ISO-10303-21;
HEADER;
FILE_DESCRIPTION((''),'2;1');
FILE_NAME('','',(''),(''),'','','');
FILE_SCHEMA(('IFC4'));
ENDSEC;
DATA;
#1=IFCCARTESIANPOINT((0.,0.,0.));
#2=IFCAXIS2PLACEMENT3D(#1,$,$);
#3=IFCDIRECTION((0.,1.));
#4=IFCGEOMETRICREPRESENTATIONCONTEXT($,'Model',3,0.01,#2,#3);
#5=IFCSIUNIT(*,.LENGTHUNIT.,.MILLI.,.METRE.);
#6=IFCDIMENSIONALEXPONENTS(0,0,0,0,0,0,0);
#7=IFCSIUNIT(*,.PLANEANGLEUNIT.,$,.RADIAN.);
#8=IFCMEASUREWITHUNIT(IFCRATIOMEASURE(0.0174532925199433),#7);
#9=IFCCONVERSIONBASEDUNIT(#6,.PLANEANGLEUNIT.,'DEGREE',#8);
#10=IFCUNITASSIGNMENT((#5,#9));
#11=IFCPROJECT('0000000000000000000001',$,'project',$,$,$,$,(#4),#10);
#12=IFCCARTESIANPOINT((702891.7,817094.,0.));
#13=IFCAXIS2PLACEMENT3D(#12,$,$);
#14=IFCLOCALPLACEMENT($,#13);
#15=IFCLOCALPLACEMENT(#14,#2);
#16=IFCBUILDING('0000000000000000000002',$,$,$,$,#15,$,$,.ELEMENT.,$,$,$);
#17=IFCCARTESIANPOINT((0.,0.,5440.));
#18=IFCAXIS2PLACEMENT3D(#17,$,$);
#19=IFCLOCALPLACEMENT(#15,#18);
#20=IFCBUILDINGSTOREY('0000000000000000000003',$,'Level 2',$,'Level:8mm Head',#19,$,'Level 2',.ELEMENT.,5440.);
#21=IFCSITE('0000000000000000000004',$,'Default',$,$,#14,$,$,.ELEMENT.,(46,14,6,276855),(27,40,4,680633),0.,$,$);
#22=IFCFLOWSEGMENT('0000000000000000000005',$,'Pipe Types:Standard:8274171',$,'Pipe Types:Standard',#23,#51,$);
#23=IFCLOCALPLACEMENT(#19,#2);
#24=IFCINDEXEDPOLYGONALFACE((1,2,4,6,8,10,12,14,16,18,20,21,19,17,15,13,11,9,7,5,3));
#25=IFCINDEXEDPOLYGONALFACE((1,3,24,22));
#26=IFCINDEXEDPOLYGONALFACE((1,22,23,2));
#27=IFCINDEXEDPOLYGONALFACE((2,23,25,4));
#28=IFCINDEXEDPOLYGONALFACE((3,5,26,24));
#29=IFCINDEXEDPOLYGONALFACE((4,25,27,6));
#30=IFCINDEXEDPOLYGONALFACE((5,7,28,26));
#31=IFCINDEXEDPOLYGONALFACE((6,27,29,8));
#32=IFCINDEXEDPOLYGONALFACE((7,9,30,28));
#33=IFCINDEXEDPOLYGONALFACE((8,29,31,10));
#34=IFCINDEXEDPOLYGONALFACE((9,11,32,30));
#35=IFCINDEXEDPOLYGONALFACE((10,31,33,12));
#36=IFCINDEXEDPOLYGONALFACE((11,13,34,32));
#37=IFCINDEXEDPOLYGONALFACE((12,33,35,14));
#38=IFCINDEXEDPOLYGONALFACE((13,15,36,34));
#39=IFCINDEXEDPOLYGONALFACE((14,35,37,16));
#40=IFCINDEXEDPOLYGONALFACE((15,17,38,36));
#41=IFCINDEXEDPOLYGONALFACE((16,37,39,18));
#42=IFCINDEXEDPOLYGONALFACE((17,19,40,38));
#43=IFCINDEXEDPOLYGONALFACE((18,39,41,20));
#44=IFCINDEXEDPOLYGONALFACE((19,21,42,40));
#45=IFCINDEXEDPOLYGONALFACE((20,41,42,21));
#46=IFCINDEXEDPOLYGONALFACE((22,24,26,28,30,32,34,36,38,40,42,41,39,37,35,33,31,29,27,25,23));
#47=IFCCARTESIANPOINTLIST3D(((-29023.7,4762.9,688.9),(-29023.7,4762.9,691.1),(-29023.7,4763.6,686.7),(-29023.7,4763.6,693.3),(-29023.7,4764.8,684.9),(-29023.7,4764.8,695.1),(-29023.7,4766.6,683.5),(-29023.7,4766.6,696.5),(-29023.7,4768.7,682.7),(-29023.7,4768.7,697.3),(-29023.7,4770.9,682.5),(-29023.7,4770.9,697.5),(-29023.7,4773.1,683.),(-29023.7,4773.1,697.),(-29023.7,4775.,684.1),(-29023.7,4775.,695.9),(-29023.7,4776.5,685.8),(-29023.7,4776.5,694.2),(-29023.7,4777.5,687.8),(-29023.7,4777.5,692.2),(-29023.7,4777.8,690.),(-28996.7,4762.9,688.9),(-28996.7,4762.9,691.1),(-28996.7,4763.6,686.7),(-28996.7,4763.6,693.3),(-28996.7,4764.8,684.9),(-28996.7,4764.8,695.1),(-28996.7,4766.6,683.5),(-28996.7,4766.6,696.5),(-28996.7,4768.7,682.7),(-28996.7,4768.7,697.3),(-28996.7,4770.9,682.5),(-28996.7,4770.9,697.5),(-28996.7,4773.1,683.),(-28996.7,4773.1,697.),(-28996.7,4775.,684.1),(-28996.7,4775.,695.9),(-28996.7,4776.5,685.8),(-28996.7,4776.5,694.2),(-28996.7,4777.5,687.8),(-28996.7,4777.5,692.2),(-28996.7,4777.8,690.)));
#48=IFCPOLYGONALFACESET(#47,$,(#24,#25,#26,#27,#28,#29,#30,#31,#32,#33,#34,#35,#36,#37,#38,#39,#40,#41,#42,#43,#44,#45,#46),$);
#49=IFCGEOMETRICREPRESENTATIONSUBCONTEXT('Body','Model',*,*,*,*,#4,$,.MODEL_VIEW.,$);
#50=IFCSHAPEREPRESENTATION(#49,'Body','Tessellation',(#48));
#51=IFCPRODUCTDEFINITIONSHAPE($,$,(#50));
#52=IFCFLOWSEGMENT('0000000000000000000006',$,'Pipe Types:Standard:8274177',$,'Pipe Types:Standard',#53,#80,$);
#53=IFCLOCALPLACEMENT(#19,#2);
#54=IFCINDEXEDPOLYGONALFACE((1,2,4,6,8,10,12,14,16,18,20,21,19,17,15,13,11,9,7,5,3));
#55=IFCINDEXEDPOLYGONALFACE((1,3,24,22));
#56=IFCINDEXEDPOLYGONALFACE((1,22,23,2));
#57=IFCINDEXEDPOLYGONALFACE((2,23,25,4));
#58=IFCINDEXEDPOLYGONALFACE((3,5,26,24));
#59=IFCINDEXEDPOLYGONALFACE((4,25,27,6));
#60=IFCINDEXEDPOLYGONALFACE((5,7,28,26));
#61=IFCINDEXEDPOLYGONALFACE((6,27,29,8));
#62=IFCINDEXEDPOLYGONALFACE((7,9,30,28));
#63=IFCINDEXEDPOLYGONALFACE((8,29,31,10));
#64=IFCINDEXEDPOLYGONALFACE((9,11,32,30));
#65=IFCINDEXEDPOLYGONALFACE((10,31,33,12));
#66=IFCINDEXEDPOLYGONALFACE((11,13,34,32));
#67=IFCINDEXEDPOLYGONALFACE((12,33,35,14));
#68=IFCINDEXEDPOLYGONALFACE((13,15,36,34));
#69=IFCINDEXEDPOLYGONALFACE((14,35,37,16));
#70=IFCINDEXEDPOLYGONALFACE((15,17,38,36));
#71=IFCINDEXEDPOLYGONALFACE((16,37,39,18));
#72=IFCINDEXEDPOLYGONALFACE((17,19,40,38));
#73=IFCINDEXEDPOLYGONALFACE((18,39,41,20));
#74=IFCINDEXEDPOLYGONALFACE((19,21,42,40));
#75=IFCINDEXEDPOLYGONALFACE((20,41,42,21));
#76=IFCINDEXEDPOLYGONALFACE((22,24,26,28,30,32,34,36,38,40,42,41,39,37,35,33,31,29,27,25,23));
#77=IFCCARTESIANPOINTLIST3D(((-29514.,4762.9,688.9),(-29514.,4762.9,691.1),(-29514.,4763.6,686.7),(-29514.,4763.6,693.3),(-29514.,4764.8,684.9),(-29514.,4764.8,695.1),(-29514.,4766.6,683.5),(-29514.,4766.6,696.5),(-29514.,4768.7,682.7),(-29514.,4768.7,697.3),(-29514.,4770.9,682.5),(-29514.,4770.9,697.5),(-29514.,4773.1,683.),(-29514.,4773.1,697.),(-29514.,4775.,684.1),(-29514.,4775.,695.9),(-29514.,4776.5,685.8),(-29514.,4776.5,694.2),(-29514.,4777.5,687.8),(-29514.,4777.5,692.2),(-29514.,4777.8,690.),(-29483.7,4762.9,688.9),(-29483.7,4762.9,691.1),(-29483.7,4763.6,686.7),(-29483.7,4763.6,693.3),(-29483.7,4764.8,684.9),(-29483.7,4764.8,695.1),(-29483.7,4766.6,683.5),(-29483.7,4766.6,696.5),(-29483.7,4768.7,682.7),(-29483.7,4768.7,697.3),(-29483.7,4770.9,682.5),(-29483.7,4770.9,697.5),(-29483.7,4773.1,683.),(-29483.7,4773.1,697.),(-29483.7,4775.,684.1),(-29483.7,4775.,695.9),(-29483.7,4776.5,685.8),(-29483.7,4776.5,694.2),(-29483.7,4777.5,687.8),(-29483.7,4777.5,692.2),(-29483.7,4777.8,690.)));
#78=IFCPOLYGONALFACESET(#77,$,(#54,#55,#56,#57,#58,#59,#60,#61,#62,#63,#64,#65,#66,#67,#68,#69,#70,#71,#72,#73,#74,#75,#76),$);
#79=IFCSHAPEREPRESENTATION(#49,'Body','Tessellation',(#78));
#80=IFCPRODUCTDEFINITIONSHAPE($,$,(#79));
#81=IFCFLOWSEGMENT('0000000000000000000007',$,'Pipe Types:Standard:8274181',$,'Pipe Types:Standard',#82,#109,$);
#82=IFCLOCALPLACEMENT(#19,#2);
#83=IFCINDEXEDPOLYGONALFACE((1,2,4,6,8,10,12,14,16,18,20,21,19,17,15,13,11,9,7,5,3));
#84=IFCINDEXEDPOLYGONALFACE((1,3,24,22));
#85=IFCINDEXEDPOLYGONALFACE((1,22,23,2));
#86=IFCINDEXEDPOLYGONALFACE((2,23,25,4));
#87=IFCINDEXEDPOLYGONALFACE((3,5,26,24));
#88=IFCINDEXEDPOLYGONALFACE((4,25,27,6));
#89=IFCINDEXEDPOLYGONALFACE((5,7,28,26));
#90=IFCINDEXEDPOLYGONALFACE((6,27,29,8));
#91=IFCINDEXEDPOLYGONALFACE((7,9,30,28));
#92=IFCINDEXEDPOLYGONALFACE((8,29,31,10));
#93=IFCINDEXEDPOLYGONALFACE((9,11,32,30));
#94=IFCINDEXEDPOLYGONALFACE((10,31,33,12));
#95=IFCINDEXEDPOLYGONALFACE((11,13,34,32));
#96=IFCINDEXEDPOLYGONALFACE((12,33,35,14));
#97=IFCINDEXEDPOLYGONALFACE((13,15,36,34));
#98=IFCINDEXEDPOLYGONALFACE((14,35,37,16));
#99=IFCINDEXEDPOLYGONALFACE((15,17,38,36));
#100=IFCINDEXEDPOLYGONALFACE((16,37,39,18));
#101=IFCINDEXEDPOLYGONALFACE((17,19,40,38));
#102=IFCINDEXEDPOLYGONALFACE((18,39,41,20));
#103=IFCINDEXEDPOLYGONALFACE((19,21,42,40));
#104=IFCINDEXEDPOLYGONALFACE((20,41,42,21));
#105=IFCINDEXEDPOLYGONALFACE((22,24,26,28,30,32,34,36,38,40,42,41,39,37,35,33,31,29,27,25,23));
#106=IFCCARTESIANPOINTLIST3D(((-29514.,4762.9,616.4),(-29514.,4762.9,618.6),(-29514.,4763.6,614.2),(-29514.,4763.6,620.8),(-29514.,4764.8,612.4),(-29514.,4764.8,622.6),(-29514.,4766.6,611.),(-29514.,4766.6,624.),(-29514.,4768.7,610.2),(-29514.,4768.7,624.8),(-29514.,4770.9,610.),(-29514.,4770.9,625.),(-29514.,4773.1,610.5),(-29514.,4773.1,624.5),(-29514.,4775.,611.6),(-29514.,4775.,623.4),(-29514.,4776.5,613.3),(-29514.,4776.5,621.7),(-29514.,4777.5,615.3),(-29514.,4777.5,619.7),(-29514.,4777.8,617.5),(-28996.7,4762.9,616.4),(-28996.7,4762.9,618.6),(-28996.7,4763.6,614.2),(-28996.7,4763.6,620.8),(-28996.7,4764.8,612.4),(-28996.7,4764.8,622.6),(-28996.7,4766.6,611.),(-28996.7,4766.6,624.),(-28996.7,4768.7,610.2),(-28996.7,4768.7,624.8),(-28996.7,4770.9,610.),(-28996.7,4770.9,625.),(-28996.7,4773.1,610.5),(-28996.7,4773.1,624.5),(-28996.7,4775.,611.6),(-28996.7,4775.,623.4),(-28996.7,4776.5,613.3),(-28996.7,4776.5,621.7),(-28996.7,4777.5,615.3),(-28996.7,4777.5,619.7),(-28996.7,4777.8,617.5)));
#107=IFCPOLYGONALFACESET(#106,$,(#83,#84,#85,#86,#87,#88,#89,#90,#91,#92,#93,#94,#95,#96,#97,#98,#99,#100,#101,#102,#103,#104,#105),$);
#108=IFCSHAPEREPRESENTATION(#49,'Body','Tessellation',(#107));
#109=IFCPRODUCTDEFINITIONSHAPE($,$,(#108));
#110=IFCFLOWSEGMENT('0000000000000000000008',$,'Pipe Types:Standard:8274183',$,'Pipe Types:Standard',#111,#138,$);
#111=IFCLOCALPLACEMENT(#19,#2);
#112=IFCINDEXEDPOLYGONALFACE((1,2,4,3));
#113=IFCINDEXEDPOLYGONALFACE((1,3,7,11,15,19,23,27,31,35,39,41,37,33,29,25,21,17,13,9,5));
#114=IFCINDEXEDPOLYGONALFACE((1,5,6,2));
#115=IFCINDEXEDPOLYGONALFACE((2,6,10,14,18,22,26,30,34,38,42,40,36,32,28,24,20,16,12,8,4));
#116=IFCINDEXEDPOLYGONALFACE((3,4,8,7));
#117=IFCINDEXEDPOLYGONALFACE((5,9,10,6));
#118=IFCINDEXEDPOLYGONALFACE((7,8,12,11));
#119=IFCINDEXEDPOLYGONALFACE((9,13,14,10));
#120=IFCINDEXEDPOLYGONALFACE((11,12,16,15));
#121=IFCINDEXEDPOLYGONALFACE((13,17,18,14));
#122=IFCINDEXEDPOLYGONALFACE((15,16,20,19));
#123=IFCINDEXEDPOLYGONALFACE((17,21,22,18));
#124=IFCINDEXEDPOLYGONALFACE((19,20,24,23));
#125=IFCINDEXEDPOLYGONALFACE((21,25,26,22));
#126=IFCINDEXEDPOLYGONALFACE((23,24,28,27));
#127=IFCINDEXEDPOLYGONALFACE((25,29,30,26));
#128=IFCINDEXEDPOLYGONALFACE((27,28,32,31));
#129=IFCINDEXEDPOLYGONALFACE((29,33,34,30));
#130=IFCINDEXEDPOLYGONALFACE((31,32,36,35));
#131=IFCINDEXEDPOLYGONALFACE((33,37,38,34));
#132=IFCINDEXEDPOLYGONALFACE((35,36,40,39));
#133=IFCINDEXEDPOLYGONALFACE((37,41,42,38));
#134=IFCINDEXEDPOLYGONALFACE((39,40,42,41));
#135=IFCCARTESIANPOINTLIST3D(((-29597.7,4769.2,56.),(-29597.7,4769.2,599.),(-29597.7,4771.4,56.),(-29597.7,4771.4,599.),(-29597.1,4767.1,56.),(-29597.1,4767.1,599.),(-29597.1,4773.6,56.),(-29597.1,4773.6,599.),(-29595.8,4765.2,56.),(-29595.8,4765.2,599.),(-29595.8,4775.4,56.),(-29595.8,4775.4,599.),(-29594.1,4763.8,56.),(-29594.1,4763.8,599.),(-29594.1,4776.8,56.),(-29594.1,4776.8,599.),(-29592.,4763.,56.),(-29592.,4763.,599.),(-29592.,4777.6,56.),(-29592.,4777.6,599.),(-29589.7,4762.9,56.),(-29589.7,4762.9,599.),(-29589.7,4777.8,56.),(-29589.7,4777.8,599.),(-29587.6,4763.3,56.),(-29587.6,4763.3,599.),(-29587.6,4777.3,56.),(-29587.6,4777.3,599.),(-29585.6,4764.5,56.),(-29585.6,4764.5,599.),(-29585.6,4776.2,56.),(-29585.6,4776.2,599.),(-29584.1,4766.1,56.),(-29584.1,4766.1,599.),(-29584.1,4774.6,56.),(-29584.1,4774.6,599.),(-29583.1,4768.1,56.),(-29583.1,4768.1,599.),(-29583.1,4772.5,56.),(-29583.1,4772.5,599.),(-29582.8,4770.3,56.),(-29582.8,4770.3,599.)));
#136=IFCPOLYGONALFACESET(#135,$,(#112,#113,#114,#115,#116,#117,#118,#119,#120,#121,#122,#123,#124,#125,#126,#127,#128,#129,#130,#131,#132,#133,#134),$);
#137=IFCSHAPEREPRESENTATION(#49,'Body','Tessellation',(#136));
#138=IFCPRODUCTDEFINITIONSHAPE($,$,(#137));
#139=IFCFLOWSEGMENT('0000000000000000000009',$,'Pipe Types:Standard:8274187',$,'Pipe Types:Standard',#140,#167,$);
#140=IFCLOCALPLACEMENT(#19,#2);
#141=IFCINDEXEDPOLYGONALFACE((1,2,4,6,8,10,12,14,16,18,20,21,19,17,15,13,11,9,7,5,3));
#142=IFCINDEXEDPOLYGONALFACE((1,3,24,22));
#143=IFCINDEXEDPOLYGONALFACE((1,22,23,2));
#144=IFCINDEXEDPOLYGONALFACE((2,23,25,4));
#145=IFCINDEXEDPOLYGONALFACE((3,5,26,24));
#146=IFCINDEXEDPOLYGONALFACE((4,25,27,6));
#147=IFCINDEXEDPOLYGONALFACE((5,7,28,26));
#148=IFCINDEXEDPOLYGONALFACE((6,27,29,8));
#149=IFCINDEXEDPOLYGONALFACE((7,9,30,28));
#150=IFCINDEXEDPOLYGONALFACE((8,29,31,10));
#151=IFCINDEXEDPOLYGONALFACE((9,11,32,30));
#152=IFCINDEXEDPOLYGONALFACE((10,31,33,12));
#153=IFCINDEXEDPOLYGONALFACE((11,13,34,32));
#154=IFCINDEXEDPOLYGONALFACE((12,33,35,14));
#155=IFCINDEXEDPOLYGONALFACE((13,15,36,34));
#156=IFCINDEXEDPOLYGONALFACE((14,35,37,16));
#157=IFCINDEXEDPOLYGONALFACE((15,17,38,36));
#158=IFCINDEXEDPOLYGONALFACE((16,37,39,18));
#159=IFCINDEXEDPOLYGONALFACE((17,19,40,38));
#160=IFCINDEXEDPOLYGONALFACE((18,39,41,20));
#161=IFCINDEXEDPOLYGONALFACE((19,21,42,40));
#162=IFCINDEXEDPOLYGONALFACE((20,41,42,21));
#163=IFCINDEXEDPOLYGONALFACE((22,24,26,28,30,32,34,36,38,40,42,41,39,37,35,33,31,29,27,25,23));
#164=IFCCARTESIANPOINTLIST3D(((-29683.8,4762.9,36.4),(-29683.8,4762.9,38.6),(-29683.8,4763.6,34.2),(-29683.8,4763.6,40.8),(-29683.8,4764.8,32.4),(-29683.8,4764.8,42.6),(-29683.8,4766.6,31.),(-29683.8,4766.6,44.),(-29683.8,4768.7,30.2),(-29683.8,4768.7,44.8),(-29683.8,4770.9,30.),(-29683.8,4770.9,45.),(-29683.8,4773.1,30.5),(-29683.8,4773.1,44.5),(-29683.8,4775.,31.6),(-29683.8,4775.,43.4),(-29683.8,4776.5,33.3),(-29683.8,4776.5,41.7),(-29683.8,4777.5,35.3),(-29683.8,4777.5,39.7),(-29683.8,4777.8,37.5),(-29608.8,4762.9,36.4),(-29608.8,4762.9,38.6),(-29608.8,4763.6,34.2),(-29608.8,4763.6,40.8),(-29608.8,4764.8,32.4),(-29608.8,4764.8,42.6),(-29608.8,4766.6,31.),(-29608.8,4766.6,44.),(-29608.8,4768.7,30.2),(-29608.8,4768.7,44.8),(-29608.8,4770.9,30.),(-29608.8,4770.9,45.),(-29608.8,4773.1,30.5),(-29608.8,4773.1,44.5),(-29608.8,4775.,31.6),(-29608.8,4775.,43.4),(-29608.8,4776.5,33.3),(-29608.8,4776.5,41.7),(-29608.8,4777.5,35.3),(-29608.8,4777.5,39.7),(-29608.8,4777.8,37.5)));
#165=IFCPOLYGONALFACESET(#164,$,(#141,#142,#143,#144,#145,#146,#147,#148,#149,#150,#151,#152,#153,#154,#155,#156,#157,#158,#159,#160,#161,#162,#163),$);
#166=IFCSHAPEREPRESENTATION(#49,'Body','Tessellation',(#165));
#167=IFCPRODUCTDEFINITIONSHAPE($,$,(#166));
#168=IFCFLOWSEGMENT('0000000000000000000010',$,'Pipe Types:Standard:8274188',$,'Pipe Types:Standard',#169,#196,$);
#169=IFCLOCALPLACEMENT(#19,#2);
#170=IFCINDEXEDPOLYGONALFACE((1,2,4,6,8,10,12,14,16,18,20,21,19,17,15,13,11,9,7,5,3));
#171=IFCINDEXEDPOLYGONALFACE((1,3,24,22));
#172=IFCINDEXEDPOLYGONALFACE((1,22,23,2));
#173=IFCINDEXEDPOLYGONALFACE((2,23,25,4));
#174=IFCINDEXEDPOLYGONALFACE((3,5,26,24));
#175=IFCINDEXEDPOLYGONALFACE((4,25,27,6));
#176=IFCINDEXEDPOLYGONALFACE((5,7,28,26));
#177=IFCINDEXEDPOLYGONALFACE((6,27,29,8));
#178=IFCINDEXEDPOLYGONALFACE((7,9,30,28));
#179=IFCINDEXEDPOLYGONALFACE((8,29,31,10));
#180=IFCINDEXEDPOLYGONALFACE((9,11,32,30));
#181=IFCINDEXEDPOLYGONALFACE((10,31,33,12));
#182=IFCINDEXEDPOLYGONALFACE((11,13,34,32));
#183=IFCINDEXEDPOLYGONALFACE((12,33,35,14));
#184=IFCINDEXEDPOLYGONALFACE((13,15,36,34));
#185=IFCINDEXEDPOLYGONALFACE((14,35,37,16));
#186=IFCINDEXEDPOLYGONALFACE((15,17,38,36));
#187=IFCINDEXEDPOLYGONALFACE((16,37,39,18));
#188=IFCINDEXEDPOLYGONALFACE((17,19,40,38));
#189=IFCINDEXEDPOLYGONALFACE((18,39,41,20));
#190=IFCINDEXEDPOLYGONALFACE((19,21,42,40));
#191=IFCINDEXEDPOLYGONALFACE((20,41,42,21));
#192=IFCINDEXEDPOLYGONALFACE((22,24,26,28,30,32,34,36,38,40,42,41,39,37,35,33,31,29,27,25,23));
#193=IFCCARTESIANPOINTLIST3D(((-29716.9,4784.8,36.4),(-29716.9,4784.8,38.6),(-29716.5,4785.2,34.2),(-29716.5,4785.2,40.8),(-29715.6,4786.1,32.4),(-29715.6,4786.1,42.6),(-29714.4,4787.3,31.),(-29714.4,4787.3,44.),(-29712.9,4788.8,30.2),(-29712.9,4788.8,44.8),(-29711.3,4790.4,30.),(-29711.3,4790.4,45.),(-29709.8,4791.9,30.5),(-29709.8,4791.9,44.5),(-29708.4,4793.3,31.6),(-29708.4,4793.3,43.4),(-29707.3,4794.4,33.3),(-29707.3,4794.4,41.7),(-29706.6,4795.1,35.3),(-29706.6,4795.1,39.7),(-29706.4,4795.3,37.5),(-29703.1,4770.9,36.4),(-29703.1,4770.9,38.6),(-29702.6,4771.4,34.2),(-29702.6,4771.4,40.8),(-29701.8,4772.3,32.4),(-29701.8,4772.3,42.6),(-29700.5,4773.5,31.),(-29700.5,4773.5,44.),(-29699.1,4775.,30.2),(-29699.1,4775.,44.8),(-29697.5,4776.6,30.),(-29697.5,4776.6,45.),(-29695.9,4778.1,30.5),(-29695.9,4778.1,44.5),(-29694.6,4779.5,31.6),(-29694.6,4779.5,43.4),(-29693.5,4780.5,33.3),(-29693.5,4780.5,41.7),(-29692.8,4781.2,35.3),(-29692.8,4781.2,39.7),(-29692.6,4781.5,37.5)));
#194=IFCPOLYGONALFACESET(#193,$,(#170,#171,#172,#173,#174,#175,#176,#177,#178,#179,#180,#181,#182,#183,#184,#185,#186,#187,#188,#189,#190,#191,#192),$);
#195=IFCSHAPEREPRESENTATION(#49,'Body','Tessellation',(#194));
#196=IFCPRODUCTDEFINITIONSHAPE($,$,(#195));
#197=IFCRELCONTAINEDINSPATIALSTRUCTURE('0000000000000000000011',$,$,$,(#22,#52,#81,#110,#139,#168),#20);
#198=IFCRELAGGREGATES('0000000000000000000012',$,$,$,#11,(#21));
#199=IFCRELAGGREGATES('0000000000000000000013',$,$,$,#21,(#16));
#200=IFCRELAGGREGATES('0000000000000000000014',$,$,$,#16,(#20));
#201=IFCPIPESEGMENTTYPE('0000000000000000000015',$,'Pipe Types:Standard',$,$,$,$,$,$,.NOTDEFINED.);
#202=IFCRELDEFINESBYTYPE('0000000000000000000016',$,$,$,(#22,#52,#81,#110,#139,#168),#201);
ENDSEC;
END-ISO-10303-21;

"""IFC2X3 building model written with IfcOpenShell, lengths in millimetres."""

from ifc_helpers import new_model, entity, si_unit, converted_unit, direction, frame, frame_2d, origin, origin_2d_with_axis, place, context, subcontext, project, spatial, circle, extrude, type_object, element, save


model = new_model("IFC2X3")

# Units and contexts
model_context = context("Model", 3, precision=0.01, world=origin(), true_north=direction((0.0, 1.0)))
body_context = subcontext(model_context, "Body", "Model", "MODEL_VIEW")
ifc_project = project(units=[si_unit("LENGTHUNIT", "METRE", prefix="MILLI"), converted_unit("PLANEANGLEUNIT", "DEGREE", entity("IfcRatioMeasure", 0.0174532925199433), si_unit("PLANEANGLEUNIT", "RADIAN"), dimensions=[0, 0, 0, 0, 0, 0, 0])], contexts=[model_context])

# Site, building, storey
site_placement = place(None, frame((702891.7, 817094.0, 0.0)))
site = spatial("IfcSite", under=ifc_project, at=site_placement, Name="Default", CompositionType="ELEMENT", RefLatitude=(46, 14, 6, 276855), RefLongitude=(27, 40, 4, 680633), RefElevation=0.0)
building_placement = place(site_placement, origin())
building = spatial("IfcBuilding", under=site, at=building_placement, CompositionType="ELEMENT")
storey_placement = place(building_placement, frame((0.0, 0.0, 5440.0)))
storey = spatial("IfcBuildingStorey", under=building, at=storey_placement, Name="Level 2", ObjectType="Level:8mm Head", LongName="Level 2", CompositionType="ELEMENT", Elevation=5440.0)

# Flow segments
pipe_segment_type = type_object("IfcPipeSegmentType", Name="Pipe Types:Standard", PredefinedType="NOTDEFINED")
flow_segment_1_placement = place(storey_placement, origin())
element("IfcFlowSegment", 1, at=flow_segment_1_placement, inside=storey, type_object=pipe_segment_type, Name="Pipe Types:Standard:8274171", ObjectType="Pipe Types:Standard", context=body_context, shape_type="SweptSolid", body=[
    extrude(circle(Radius=7.5, at=frame_2d((0.0, 0.0), x_axis=(1.0, 0.0))), frame((-29023.7, 4770.3, 690.0), z_axis=(1.0, 0.0, 0.0), x_axis=(0.0, 1.0, 0.0)), (0.0, 0.0, 1.0), 27.0),
])
flow_segment_2_placement = place(storey_placement, origin())
element("IfcFlowSegment", 2, at=flow_segment_2_placement, inside=storey, type_object=pipe_segment_type, Name="Pipe Types:Standard:8274177", ObjectType="Pipe Types:Standard", context=body_context, shape_type="SweptSolid", body=[
    extrude(circle(Radius=7.5, at=frame_2d((0.0, 0.0), x_axis=(1.0, 0.0))), frame((-29514.0, 4770.3, 690.0), z_axis=(1.0, 0.0, 0.0), x_axis=(0.0, 1.0, 0.0)), (0.0, 0.0, 1.0), 30.3),
])
flow_segment_3_placement = place(storey_placement, origin())
element("IfcFlowSegment", 3, at=flow_segment_3_placement, inside=storey, type_object=pipe_segment_type, Name="Pipe Types:Standard:8274181", ObjectType="Pipe Types:Standard", context=body_context, shape_type="SweptSolid", body=[
    extrude(circle(Radius=7.5, at=frame_2d((0.0, 0.0), x_axis=(1.0, 0.0))), frame((-29514.0, 4770.3, 617.5), z_axis=(1.0, 0.0, 0.0), x_axis=(0.0, 1.0, 0.0)), (0.0, 0.0, 1.0), 517.3),
])
flow_segment_4_placement = place(storey_placement, origin())
element("IfcFlowSegment", 4, at=flow_segment_4_placement, inside=storey, type_object=pipe_segment_type, Name="Pipe Types:Standard:8274183", ObjectType="Pipe Types:Standard", context=body_context, shape_type="SweptSolid", body=[
    extrude(circle(Radius=7.5, at=origin_2d_with_axis()), frame((-29590.3, 4770.3, 56.0)), (0.0, 0.0, 1.0), 543.0),
])
flow_segment_5_placement = place(storey_placement, origin())
element("IfcFlowSegment", 5, at=flow_segment_5_placement, inside=storey, type_object=pipe_segment_type, Name="Pipe Types:Standard:8274187", ObjectType="Pipe Types:Standard", context=body_context, shape_type="SweptSolid", body=[
    extrude(circle(Radius=7.5, at=frame_2d((0.0, 0.0), x_axis=(1.0, 0.0))), frame((-29683.8, 4770.3, 37.5), z_axis=(1.0, 0.0, 0.0), x_axis=(0.0, 1.0, 0.0)), (0.0, 0.0, 1.0), 75.0),
])
flow_segment_6_placement = place(storey_placement, origin())
element("IfcFlowSegment", 6, at=flow_segment_6_placement, inside=storey, type_object=pipe_segment_type, Name="Pipe Types:Standard:8274188", ObjectType="Pipe Types:Standard", context=body_context, shape_type="SweptSolid", body=[
    extrude(circle(Radius=7.5, at=origin_2d_with_axis()), frame((-29711.7, 4790.0, 37.5), z_axis=(0.707107, -0.707107, 0.0), x_axis=(0.707107, 0.707107, 0.0)), (0.0, 0.0, 1.0), 19.6),
])

save(model, "model.ifc")
